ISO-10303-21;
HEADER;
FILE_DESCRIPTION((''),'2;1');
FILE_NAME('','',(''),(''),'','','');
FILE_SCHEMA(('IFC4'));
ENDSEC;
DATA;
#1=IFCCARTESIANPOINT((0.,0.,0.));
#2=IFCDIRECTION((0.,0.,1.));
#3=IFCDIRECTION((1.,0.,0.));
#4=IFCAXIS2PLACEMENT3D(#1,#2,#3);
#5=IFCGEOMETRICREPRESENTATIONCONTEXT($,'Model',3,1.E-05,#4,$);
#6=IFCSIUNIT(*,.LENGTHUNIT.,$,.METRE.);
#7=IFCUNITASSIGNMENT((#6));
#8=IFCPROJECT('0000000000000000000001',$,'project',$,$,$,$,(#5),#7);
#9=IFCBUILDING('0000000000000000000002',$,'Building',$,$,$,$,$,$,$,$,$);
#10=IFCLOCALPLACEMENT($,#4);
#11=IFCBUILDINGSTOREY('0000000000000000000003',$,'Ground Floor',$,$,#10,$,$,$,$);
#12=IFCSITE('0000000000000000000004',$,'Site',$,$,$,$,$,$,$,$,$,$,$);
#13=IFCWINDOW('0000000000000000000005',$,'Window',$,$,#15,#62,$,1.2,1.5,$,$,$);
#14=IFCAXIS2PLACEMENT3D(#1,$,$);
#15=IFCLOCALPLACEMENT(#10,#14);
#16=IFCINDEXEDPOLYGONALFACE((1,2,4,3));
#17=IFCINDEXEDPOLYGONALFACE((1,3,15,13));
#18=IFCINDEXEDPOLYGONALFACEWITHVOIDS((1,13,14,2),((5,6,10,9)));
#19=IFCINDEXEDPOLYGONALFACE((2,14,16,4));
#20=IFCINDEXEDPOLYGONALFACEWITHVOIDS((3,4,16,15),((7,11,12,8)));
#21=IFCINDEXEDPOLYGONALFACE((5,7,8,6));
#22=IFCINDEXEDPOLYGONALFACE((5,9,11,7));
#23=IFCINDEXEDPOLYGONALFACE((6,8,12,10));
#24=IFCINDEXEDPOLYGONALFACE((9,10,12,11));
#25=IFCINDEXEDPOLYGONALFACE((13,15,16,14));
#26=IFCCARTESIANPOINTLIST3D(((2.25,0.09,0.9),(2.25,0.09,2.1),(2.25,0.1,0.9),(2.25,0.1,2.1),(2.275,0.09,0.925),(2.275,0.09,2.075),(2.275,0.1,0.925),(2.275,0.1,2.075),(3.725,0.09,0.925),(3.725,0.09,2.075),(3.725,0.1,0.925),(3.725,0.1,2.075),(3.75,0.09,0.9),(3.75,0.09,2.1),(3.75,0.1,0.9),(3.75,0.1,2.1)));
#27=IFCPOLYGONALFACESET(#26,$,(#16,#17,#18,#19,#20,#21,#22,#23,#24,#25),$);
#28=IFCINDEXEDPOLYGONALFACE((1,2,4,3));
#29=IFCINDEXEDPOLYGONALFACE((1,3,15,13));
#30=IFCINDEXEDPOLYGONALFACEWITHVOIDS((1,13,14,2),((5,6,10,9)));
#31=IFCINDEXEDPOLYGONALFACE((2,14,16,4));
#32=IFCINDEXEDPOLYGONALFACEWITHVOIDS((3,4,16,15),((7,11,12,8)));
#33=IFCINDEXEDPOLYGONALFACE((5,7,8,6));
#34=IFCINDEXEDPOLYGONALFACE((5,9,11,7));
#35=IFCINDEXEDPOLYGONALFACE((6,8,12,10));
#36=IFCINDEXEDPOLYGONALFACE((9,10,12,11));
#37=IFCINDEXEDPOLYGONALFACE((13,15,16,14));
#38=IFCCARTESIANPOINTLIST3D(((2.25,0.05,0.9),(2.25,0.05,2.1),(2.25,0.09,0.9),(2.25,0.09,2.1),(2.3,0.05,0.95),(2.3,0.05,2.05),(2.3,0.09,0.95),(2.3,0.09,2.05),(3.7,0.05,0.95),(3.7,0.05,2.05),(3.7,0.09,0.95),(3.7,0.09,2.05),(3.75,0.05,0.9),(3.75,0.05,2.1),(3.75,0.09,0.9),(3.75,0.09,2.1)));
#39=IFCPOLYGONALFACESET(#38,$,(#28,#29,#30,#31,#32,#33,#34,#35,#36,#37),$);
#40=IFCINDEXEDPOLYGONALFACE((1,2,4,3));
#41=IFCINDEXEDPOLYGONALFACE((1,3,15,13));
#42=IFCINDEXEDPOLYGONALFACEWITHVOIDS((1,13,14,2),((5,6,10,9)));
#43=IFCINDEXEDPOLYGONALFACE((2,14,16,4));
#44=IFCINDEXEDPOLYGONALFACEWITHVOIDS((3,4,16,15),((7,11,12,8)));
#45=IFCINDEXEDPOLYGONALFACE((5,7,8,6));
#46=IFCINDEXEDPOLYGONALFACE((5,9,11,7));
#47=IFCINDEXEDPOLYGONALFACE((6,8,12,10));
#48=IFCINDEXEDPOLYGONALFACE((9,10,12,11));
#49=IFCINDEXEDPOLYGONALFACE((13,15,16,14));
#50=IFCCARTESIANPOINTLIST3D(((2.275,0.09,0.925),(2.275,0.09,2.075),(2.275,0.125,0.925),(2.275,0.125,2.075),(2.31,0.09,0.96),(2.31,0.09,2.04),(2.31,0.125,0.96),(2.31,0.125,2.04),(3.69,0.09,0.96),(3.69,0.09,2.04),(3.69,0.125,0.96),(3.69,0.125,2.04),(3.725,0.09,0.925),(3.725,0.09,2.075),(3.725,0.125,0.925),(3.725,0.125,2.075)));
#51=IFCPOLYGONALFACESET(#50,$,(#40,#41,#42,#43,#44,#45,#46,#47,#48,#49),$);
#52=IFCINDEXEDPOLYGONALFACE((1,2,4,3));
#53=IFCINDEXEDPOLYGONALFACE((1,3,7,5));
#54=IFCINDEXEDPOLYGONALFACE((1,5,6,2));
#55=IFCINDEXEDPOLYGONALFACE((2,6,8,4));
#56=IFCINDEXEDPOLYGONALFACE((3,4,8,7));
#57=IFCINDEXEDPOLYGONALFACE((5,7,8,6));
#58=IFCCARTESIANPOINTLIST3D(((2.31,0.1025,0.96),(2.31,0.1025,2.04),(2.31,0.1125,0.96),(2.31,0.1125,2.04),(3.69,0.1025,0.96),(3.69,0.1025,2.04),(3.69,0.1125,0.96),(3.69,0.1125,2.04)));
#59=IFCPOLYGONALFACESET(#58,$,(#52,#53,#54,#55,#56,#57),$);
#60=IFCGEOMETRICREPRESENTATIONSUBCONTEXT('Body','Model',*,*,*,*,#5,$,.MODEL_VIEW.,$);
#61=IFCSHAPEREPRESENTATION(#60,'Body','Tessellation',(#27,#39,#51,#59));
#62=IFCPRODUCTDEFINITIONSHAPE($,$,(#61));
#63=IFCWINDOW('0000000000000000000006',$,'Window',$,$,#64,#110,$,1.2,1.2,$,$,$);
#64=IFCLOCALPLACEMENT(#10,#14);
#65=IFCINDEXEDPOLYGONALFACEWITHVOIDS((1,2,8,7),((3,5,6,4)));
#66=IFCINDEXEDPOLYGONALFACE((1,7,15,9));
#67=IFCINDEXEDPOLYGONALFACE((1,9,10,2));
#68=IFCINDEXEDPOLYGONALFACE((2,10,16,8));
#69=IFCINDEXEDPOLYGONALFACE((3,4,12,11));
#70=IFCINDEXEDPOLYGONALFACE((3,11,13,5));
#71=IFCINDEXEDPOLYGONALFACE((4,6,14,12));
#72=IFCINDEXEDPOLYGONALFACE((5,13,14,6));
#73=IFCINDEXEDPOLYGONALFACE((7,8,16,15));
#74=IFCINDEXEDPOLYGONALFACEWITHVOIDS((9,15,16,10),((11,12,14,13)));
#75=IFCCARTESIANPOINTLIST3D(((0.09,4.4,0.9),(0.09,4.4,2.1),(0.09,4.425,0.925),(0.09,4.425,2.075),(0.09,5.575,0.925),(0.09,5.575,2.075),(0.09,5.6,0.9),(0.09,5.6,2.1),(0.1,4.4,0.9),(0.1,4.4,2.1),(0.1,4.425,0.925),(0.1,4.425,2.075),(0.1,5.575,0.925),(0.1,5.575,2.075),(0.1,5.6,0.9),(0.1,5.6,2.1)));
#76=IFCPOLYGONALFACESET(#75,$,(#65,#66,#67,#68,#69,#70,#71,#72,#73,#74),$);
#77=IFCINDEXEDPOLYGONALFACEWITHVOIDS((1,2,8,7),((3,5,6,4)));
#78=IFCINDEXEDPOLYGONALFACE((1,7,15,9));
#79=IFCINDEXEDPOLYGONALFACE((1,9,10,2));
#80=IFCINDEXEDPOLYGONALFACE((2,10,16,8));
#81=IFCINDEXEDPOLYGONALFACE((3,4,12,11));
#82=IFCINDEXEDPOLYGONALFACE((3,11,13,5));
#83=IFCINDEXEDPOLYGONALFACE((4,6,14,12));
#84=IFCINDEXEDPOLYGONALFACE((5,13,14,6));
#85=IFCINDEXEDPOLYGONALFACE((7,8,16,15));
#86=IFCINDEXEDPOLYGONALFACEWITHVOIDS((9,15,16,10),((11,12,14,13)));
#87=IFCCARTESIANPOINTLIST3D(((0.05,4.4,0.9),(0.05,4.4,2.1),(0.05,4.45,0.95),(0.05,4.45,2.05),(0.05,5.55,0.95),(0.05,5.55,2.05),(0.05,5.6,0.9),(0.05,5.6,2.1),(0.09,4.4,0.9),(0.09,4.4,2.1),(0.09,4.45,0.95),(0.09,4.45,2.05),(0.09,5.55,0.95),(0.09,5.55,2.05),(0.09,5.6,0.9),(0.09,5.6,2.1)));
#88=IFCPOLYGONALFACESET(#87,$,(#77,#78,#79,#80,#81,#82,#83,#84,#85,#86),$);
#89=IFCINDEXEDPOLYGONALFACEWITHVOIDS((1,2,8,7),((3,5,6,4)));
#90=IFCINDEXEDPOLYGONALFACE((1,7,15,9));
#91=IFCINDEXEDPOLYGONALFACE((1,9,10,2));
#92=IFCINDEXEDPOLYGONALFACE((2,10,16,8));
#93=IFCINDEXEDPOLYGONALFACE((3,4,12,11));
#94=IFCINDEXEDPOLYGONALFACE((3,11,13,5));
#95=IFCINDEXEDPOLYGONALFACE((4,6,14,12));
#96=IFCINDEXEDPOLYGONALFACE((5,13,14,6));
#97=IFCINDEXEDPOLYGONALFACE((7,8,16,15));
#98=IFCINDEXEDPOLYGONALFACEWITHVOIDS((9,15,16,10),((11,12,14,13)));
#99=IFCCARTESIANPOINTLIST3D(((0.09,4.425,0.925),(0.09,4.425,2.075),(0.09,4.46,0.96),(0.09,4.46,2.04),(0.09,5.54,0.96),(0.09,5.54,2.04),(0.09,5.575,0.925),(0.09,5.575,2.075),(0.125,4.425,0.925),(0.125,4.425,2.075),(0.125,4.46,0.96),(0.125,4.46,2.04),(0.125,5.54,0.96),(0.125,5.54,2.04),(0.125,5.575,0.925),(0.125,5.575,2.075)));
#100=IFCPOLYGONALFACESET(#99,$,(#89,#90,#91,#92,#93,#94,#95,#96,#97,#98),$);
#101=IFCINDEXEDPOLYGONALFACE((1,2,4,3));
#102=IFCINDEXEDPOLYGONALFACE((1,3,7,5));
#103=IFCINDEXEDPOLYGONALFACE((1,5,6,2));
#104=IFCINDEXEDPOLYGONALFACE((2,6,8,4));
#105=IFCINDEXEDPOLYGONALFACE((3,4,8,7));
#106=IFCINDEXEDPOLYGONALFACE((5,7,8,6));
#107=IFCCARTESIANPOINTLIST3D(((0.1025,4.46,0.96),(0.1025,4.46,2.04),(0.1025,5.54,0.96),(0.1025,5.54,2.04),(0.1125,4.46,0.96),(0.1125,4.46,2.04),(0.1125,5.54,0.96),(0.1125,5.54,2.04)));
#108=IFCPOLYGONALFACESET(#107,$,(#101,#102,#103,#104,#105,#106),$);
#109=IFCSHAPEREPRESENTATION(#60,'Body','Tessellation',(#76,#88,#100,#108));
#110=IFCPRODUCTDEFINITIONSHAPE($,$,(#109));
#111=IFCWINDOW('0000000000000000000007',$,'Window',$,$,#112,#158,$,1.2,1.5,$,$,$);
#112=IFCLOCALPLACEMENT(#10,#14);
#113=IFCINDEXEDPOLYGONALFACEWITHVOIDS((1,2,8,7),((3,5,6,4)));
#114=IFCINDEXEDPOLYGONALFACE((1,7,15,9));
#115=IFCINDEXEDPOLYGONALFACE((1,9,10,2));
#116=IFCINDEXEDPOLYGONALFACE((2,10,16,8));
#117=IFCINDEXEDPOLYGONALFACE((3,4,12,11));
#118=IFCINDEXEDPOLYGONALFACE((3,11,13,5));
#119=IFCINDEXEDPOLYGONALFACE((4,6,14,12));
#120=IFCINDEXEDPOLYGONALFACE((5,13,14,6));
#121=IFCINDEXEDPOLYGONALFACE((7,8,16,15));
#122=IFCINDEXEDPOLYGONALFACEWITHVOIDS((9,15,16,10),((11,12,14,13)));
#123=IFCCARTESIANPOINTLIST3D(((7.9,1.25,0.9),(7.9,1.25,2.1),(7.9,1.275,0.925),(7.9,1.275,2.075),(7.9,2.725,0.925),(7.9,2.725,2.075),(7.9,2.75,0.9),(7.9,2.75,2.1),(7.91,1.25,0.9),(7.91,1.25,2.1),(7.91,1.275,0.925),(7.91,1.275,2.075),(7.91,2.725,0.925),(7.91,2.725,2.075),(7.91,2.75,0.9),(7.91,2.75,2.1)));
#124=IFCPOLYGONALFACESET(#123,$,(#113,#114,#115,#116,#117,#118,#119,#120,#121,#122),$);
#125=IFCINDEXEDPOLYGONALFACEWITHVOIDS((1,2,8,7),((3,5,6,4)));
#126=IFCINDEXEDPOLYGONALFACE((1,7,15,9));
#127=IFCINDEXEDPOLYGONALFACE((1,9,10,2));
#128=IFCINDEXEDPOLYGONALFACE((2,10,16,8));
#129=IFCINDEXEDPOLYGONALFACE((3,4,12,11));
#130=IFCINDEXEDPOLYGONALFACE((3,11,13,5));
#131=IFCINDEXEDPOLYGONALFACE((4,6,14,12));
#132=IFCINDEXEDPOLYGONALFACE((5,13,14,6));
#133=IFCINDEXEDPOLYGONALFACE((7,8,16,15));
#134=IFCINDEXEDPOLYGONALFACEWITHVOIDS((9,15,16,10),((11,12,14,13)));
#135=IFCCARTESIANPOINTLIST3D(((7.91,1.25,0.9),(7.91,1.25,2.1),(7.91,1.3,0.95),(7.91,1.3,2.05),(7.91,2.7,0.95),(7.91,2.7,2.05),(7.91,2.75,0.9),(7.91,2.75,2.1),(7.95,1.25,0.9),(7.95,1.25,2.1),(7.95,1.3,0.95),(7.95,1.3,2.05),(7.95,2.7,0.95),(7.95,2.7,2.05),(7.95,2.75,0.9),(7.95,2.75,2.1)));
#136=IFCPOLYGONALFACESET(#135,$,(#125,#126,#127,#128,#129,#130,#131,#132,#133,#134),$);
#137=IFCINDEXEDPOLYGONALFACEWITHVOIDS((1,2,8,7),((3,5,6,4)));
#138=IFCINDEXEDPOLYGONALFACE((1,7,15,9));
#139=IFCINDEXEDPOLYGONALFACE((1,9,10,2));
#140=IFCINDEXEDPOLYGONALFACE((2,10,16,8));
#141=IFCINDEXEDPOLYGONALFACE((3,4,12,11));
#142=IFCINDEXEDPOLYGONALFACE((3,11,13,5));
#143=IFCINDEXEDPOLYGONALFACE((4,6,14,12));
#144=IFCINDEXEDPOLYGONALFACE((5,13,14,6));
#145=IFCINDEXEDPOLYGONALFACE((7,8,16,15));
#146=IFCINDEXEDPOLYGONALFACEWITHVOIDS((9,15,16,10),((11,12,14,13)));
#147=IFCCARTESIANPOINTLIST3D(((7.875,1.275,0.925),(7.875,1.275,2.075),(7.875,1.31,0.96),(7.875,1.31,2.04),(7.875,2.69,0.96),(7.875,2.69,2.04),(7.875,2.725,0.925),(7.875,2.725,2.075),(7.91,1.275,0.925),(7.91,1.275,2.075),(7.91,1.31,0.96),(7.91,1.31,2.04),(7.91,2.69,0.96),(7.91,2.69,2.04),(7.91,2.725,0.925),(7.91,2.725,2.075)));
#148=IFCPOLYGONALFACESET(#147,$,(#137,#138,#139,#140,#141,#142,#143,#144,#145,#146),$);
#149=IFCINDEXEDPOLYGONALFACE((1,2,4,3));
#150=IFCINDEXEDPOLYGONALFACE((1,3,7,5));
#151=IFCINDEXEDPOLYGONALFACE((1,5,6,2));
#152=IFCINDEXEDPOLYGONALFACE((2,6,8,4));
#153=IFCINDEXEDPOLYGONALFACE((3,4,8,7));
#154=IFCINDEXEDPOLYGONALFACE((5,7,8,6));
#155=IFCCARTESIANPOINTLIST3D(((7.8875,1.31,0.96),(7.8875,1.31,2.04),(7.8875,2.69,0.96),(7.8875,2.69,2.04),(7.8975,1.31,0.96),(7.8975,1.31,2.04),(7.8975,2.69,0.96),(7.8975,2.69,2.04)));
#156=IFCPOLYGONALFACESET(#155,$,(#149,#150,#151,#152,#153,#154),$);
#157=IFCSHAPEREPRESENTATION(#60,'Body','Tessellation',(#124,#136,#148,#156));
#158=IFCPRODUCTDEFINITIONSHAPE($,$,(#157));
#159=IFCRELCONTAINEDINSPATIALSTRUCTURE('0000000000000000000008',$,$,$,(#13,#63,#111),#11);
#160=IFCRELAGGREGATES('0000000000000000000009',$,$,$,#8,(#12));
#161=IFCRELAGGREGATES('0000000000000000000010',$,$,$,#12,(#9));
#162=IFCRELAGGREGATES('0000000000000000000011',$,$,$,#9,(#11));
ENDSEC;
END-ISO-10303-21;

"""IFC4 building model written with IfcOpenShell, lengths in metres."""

from ifc_helpers import new_model, si_unit, frame, origin_with_axes, place, context, subcontext, project, spatial, line, indexed_curve, outline, extrude, element, save


model = new_model("IFC4")

# Units and contexts
model_context = context("Model", 3, precision=1e-05, world=origin_with_axes())
body_context = subcontext(model_context, "Body", "Model", "MODEL_VIEW")
ifc_project = project(units=[si_unit("LENGTHUNIT", "METRE")], contexts=[model_context])

# Site, building, storey
site = spatial("IfcSite", under=ifc_project, Name="Site")
building = spatial("IfcBuilding", under=site, Name="Building")
storey_placement = place(None, origin_with_axes())
storey = spatial("IfcBuildingStorey", under=building, at=storey_placement, Name="Ground Floor")

# Windows
window_1_placement = place(storey_placement, frame((2.25, 0.0, 0.9), z_axis=(0.0, 0.0, 1.0), x_axis=(1.0, 0.0, 0.0)))
element("IfcWindow", 1, at=window_1_placement, inside=storey, Name="Window", OverallHeight=1.2, OverallWidth=1.5, context=body_context, shape_type="SweptSolid", body=[
    extrude(outline(indexed_curve([(0.0, 0.0), (1.5, 0.0), (1.5, 1.2), (0.0, 1.2)], segments=[line(1, 2, 3, 4, 1)]), holes=[indexed_curve([(0.025, 0.025), (1.475, 0.025), (1.475, 1.175), (0.025, 1.175)], segments=[line(1, 2, 3, 4, 1)])]), frame((0.0, 0.09, 0.0), z_axis=(0.0, -1.0, 0.0), x_axis=(1.0, 0.0, 0.0)), (0.0, 0.0, -1.0), 0.01),
    extrude(outline(indexed_curve([(0.0, 0.0), (1.5, 0.0), (1.5, 1.2), (0.0, 1.2)], segments=[line(1, 2, 3, 4, 1)]), holes=[indexed_curve([(0.05, 0.05), (1.45, 0.05), (1.45, 1.15), (0.05, 1.15)], segments=[line(1, 2, 3, 4, 1)])]), frame((0.0, 0.05, 0.0), z_axis=(0.0, -1.0, 0.0), x_axis=(1.0, 0.0, 0.0)), (0.0, 0.0, -1.0), 0.04),
    extrude(outline(indexed_curve([(0.0, 0.0), (1.45, 0.0), (1.45, 1.15), (0.0, 1.15)], segments=[line(1, 2, 3, 4, 1)]), holes=[indexed_curve([(0.035, 0.035), (1.415, 0.035), (1.415, 1.115), (0.035, 1.115)], segments=[line(1, 2, 3, 4, 1)])]), frame((0.025, 0.09, 0.025), z_axis=(0.0, -1.0, 0.0), x_axis=(1.0, 0.0, 0.0)), (0.0, 0.0, -1.0), 0.035),
    extrude(outline(indexed_curve([(0.035, 0.035), (1.415, 0.035), (1.415, 1.115), (0.035, 1.115)], segments=[line(1, 2, 3, 4, 1)])), frame((0.025, 0.1025, 0.025), z_axis=(0.0, -1.0, 0.0), x_axis=(1.0, 0.0, 0.0)), (0.0, 0.0, -1.0), 0.01),
])
window_2_placement = place(storey_placement, frame((0.0, 5.6, 0.9), z_axis=(0.0, 0.0, 1.0), x_axis=(0.0, -1.0, 0.0)))
element("IfcWindow", 2, at=window_2_placement, inside=storey, Name="Window", OverallHeight=1.2, OverallWidth=1.2, context=body_context, shape_type="SweptSolid", body=[
    extrude(outline(indexed_curve([(0.0, 0.0), (1.2, 0.0), (1.2, 1.2), (0.0, 1.2)], segments=[line(1, 2, 3, 4, 1)]), holes=[indexed_curve([(0.025, 0.025), (1.175, 0.025), (1.175, 1.175), (0.025, 1.175)], segments=[line(1, 2, 3, 4, 1)])]), frame((0.0, 0.09, 0.0), z_axis=(0.0, -1.0, 0.0), x_axis=(1.0, 0.0, 0.0)), (0.0, 0.0, -1.0), 0.01),
    extrude(outline(indexed_curve([(0.0, 0.0), (1.2, 0.0), (1.2, 1.2), (0.0, 1.2)], segments=[line(1, 2, 3, 4, 1)]), holes=[indexed_curve([(0.05, 0.05), (1.15, 0.05), (1.15, 1.15), (0.05, 1.15)], segments=[line(1, 2, 3, 4, 1)])]), frame((0.0, 0.05, 0.0), z_axis=(0.0, -1.0, 0.0), x_axis=(1.0, 0.0, 0.0)), (0.0, 0.0, -1.0), 0.04),
    extrude(outline(indexed_curve([(0.0, 0.0), (1.15, 0.0), (1.15, 1.15), (0.0, 1.15)], segments=[line(1, 2, 3, 4, 1)]), holes=[indexed_curve([(0.035, 0.035), (1.115, 0.035), (1.115, 1.115), (0.035, 1.115)], segments=[line(1, 2, 3, 4, 1)])]), frame((0.025, 0.09, 0.025), z_axis=(0.0, -1.0, 0.0), x_axis=(1.0, 0.0, 0.0)), (0.0, 0.0, -1.0), 0.035),
    extrude(outline(indexed_curve([(0.035, 0.035), (1.115, 0.035), (1.115, 1.115), (0.035, 1.115)], segments=[line(1, 2, 3, 4, 1)])), frame((0.025, 0.1025, 0.025), z_axis=(0.0, -1.0, 0.0), x_axis=(1.0, 0.0, 0.0)), (0.0, 0.0, -1.0), 0.01),
])
window_3_placement = place(storey_placement, frame((8.0, 1.25, 0.9), z_axis=(0.0, 0.0, 1.0), x_axis=(0.0, 1.0, 0.0)))
element("IfcWindow", 3, at=window_3_placement, inside=storey, Name="Window", OverallHeight=1.2, OverallWidth=1.5, context=body_context, shape_type="SweptSolid", body=[
    extrude(outline(indexed_curve([(0.0, 0.0), (1.5, 0.0), (1.5, 1.2), (0.0, 1.2)], segments=[line(1, 2, 3, 4, 1)]), holes=[indexed_curve([(0.025, 0.025), (1.475, 0.025), (1.475, 1.175), (0.025, 1.175)], segments=[line(1, 2, 3, 4, 1)])]), frame((0.0, 0.09, 0.0), z_axis=(0.0, -1.0, 0.0), x_axis=(1.0, 0.0, 0.0)), (0.0, 0.0, -1.0), 0.01),
    extrude(outline(indexed_curve([(0.0, 0.0), (1.5, 0.0), (1.5, 1.2), (0.0, 1.2)], segments=[line(1, 2, 3, 4, 1)]), holes=[indexed_curve([(0.05, 0.05), (1.45, 0.05), (1.45, 1.15), (0.05, 1.15)], segments=[line(1, 2, 3, 4, 1)])]), frame((0.0, 0.05, 0.0), z_axis=(0.0, -1.0, 0.0), x_axis=(1.0, 0.0, 0.0)), (0.0, 0.0, -1.0), 0.04),
    extrude(outline(indexed_curve([(0.0, 0.0), (1.45, 0.0), (1.45, 1.15), (0.0, 1.15)], segments=[line(1, 2, 3, 4, 1)]), holes=[indexed_curve([(0.035, 0.035), (1.415, 0.035), (1.415, 1.115), (0.035, 1.115)], segments=[line(1, 2, 3, 4, 1)])]), frame((0.025, 0.09, 0.025), z_axis=(0.0, -1.0, 0.0), x_axis=(1.0, 0.0, 0.0)), (0.0, 0.0, -1.0), 0.035),
    extrude(outline(indexed_curve([(0.035, 0.035), (1.415, 0.035), (1.415, 1.115), (0.035, 1.115)], segments=[line(1, 2, 3, 4, 1)])), frame((0.025, 0.1025, 0.025), z_axis=(0.0, -1.0, 0.0), x_axis=(1.0, 0.0, 0.0)), (0.0, 0.0, -1.0), 0.01),
])

save(model, "model.ifc")
